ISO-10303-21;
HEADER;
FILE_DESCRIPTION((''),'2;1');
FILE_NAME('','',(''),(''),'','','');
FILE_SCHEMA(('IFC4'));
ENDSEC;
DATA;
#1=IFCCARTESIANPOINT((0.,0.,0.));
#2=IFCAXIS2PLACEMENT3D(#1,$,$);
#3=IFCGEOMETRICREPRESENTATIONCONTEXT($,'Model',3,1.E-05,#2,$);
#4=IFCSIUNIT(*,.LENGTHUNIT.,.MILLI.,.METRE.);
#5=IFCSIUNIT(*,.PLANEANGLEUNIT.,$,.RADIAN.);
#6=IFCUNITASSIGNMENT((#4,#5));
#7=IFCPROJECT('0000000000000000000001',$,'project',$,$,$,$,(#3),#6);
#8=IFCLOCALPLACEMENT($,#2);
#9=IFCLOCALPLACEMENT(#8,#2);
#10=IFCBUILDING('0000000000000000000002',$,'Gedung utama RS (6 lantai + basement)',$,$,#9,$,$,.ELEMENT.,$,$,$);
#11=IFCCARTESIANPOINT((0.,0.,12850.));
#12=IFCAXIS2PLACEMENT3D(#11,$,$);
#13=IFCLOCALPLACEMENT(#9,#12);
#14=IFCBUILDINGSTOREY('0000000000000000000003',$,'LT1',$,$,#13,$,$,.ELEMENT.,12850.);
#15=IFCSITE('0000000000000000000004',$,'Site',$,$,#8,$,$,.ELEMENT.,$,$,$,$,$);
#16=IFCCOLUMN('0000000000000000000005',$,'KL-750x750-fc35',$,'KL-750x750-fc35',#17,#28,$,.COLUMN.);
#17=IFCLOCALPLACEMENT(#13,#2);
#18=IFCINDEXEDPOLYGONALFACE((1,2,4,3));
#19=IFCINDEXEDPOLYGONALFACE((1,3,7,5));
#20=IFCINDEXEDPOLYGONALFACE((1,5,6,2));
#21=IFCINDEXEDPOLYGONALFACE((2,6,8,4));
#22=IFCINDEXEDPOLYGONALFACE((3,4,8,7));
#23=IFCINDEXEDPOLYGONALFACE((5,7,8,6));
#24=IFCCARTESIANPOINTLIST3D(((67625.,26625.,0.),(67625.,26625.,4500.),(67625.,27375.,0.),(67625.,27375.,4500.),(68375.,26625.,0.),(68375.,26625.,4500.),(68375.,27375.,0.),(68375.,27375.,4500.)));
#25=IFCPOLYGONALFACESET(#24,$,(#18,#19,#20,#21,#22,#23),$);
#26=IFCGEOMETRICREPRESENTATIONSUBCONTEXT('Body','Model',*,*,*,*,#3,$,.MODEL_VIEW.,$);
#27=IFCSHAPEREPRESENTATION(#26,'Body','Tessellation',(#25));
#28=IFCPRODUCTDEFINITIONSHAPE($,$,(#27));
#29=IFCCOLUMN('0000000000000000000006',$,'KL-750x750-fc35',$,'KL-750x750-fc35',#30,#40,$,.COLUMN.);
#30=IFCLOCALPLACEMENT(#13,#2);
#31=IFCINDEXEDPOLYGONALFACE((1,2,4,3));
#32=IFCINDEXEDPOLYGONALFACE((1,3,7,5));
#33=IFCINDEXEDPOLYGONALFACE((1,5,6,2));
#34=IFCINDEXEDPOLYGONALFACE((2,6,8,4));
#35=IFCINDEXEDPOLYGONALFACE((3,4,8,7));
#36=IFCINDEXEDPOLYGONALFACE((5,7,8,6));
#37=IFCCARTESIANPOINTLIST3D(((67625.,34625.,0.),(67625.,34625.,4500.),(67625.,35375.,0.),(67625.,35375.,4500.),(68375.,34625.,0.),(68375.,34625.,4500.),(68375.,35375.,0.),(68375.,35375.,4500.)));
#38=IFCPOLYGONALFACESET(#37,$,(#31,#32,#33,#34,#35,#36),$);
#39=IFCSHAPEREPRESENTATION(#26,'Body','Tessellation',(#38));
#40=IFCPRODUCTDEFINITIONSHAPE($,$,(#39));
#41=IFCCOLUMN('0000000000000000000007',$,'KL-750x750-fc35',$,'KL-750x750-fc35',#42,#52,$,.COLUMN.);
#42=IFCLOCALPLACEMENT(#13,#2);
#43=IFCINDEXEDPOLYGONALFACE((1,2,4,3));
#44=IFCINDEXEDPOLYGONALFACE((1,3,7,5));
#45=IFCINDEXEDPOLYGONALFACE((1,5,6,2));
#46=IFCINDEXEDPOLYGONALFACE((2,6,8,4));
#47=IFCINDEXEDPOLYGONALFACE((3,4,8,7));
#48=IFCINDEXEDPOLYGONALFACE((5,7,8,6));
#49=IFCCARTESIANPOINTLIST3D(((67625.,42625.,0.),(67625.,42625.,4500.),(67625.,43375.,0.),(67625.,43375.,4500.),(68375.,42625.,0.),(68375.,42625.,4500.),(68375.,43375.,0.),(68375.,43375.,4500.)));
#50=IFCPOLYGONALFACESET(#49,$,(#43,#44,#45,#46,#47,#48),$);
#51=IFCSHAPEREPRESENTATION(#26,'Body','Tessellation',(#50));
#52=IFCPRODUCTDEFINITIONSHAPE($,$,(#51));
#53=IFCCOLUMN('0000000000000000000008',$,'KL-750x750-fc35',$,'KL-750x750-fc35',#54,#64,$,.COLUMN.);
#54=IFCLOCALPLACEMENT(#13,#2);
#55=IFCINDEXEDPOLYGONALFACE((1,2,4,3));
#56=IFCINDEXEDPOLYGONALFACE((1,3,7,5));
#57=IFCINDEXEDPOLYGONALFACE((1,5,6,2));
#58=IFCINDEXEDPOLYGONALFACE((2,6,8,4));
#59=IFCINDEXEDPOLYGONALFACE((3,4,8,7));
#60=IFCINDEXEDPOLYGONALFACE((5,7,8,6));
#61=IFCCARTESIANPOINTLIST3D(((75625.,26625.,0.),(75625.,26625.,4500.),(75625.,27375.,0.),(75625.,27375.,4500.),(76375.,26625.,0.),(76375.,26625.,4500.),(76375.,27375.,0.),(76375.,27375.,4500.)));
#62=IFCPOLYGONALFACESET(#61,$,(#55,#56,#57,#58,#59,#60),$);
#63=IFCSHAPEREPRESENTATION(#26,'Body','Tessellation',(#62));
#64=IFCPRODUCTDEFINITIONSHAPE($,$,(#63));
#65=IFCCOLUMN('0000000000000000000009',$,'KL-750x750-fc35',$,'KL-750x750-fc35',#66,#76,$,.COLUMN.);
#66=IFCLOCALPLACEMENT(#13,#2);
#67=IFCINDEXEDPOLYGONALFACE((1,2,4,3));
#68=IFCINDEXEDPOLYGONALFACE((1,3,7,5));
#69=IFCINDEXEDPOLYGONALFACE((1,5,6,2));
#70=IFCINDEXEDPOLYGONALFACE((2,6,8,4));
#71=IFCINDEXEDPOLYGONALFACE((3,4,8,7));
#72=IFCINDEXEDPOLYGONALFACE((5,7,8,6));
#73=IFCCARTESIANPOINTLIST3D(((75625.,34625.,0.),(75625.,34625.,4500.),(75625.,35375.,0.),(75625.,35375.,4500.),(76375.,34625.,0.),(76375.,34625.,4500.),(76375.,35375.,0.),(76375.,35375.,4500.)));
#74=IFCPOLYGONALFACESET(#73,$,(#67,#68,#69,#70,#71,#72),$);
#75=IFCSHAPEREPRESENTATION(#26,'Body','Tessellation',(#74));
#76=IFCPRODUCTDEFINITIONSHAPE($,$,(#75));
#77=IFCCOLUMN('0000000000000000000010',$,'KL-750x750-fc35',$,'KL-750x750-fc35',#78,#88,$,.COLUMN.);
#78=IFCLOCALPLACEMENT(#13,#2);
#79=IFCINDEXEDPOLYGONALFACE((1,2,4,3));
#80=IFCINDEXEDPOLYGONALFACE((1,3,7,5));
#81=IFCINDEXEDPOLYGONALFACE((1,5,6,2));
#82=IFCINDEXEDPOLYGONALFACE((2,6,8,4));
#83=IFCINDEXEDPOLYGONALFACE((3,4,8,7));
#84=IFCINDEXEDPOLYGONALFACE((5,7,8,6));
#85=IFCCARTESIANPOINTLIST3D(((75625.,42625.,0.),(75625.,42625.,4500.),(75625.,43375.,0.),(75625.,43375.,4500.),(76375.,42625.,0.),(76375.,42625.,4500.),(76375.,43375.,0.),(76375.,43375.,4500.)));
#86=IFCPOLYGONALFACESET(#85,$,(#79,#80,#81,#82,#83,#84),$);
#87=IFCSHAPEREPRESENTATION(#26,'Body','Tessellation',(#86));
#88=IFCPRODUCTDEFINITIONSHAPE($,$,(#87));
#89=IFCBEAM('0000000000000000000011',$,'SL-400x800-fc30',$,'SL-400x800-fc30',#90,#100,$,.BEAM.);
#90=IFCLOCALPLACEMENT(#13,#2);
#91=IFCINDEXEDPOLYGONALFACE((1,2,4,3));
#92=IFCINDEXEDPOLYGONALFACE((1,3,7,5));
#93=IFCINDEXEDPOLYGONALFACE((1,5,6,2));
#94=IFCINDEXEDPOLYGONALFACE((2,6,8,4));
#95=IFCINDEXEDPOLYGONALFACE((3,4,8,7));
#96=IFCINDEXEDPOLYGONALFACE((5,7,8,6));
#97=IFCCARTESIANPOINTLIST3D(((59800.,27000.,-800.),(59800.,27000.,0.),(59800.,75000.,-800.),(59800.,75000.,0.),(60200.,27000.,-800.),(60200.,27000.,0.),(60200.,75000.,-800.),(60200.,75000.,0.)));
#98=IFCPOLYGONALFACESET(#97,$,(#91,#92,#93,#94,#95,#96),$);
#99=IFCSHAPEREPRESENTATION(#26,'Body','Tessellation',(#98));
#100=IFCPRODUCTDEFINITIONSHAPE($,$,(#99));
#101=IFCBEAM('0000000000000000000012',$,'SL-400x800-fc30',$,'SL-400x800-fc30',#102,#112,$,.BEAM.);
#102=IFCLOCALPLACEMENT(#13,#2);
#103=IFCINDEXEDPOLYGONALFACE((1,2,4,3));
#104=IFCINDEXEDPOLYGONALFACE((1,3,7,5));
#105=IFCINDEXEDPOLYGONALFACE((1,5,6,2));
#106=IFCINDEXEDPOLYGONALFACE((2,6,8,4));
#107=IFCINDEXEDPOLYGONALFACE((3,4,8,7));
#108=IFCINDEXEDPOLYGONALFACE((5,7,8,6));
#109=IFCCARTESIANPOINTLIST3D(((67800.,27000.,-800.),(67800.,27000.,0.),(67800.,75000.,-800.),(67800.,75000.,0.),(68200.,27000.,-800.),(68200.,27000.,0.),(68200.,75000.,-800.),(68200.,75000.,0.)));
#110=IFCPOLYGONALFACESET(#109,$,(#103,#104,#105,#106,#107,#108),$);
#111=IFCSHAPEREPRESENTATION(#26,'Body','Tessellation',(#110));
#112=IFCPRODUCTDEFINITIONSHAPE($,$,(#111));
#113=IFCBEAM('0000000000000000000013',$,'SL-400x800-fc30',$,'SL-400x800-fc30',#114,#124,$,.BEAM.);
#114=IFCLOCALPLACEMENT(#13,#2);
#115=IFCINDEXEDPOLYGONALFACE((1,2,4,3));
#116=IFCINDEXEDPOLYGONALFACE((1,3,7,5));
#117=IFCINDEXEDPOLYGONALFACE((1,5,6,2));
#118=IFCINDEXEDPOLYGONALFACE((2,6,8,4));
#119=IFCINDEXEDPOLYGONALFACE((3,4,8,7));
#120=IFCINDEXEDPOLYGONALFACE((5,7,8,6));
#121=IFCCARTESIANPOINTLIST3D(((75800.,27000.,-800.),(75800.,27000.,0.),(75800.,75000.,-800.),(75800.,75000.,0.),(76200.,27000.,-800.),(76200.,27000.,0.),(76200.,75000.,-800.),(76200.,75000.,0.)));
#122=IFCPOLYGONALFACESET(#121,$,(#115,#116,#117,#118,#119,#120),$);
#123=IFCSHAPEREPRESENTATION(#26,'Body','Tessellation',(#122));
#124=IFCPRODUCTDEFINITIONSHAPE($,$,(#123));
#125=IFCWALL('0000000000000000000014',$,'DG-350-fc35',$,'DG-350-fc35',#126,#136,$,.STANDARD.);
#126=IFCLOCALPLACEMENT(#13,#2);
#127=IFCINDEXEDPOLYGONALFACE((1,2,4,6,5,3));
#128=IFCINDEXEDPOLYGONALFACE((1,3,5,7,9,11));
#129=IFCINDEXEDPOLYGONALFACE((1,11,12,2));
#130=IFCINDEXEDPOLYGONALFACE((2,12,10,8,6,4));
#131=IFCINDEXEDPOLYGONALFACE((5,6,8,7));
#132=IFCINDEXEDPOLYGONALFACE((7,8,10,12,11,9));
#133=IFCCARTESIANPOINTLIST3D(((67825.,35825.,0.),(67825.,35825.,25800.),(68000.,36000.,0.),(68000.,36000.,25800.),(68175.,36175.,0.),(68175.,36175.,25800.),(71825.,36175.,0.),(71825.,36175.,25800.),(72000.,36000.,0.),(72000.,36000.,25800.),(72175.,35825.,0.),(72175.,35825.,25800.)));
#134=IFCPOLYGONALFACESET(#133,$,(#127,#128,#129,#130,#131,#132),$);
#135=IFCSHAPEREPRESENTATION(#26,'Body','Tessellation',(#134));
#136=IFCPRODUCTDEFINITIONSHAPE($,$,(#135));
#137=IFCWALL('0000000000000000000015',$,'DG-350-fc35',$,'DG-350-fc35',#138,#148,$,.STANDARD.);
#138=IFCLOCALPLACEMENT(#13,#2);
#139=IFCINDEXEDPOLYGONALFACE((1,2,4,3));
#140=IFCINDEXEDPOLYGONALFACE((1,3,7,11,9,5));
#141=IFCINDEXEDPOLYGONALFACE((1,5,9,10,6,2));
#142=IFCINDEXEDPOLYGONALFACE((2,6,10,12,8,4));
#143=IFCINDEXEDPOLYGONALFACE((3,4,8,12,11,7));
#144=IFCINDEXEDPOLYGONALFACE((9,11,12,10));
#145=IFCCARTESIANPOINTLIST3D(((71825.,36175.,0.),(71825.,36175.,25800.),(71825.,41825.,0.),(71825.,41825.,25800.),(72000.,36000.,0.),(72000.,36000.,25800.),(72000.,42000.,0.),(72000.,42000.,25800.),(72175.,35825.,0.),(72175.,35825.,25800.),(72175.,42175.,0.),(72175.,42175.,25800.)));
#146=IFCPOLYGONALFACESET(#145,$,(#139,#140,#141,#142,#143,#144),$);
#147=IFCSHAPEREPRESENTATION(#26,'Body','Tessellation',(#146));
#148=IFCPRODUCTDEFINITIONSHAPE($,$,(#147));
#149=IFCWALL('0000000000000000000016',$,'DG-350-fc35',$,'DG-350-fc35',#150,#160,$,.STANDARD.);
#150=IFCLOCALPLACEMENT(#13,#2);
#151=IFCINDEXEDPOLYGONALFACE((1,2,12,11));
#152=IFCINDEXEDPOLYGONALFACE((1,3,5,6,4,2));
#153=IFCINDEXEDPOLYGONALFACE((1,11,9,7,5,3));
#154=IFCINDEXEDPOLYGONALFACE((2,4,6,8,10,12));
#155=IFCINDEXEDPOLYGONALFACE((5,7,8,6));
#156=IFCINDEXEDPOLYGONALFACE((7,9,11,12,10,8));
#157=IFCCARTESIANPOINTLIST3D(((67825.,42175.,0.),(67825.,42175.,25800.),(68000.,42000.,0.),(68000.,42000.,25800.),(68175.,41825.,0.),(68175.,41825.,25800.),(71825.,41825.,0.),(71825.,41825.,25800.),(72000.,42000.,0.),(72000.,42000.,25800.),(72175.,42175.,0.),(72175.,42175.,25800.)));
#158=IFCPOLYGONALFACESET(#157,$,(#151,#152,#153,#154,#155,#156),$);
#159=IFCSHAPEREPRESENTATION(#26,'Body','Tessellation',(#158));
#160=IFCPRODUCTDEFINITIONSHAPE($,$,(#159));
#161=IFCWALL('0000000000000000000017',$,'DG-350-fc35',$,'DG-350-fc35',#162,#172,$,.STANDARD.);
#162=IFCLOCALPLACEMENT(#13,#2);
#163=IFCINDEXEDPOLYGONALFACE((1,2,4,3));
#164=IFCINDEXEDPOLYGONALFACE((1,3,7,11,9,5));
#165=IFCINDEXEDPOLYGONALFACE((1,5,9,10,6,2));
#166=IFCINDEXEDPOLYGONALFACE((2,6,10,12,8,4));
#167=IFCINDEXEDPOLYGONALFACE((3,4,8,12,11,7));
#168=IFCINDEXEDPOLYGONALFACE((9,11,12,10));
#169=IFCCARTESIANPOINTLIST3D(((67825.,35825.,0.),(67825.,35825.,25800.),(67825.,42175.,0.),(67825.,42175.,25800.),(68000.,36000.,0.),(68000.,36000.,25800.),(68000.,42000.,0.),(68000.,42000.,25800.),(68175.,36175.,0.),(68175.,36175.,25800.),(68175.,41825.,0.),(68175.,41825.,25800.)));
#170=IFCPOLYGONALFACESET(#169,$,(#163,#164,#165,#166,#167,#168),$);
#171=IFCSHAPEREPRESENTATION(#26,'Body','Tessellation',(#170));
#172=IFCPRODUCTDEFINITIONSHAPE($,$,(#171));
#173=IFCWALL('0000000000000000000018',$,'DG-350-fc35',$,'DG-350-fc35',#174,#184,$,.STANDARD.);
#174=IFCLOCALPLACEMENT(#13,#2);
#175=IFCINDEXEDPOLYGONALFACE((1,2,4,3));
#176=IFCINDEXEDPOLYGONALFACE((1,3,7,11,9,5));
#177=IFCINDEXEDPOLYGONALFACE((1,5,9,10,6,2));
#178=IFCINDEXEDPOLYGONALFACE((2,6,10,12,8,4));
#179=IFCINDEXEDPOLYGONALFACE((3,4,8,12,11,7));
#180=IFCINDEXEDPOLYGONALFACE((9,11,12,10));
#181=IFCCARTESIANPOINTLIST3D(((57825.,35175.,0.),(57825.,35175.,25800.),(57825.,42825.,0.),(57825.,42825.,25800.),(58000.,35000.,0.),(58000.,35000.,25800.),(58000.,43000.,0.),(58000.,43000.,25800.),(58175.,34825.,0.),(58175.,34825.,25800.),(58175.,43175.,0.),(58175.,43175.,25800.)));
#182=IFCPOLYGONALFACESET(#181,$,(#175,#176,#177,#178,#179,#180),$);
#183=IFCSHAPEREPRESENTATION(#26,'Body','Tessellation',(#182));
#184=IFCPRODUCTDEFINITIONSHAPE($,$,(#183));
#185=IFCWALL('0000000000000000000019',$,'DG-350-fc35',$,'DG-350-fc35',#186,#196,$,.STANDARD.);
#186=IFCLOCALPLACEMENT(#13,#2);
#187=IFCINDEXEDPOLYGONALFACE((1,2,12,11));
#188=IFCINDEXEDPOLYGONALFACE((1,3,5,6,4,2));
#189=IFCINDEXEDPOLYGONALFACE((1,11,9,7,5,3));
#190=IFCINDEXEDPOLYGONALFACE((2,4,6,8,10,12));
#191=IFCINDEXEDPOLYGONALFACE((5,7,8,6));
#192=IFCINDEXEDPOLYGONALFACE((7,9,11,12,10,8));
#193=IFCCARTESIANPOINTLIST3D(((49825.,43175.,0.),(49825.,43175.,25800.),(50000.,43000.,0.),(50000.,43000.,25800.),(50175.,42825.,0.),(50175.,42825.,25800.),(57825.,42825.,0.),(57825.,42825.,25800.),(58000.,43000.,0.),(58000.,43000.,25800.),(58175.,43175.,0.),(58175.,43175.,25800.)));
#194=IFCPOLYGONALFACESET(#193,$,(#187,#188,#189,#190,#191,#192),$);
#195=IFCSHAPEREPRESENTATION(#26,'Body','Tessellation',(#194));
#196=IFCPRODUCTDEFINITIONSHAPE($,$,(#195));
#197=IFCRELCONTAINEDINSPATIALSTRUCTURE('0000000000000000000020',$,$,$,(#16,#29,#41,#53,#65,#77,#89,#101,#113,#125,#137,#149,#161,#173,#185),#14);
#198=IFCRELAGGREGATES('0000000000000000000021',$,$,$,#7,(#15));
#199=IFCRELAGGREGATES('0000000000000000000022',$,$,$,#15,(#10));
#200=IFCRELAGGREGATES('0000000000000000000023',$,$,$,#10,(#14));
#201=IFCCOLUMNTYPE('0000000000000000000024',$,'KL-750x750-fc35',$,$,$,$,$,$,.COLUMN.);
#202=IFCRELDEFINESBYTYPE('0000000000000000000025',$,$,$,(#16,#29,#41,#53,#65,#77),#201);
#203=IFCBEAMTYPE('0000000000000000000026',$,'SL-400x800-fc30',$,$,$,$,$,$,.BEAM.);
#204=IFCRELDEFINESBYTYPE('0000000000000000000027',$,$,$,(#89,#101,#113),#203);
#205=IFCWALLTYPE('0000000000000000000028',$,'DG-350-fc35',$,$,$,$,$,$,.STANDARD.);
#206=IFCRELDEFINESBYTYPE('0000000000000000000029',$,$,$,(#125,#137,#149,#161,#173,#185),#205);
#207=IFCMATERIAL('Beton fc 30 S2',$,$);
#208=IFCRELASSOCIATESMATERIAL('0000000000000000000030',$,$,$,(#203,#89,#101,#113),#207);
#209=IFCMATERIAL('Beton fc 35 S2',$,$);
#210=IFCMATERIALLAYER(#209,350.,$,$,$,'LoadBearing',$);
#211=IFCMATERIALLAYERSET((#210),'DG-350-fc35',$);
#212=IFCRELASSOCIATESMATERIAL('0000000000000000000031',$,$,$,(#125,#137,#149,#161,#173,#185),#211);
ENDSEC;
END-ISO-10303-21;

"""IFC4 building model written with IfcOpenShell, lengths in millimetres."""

from ifc_helpers import new_model, si_unit, frame, origin, origin_2d, place, context, subcontext, project, spatial, polyline, rectangle, outline, extrude, material, layer, layer_set, layer_usage, material_profile, profile_set, profile_usage, type_object, element, save


model = new_model("IFC4")

# Units and contexts
model_context = context("Model", 3, precision=1e-05, world=origin())
body_context = subcontext(model_context, "Body", "Model", "MODEL_VIEW")
ifc_project = project(units=[si_unit("LENGTHUNIT", "METRE", prefix="MILLI"), si_unit("PLANEANGLEUNIT", "RADIAN")], contexts=[model_context])

# Site, building, storey
site_placement = place(None, origin())
site = spatial("IfcSite", under=ifc_project, at=site_placement, Name="Site", CompositionType="ELEMENT")
building_placement = place(site_placement, origin())
building = spatial("IfcBuilding", under=site, at=building_placement, Name="Gedung utama RS (6 lantai + basement)", CompositionType="ELEMENT")
storey_placement = place(building_placement, frame((0.0, 0.0, 12850.0)))
storey = spatial("IfcBuildingStorey", under=building, at=storey_placement, Name="LT1", CompositionType="ELEMENT", Elevation=12850.0)

# Columns
ifc_material_profile_1 = material_profile(None, rectangle(XDim=750.0, YDim=750.0, at=origin_2d()), Name="KL-750x750-fc35")
ifc_profile_set_1 = profile_set([ifc_material_profile_1], Name="KL-750x750-fc35")
ifc_profile_usage_1 = profile_usage(ifc_profile_set_1, cardinal=5)
column_type = type_object("IfcColumnType", Name="KL-750x750-fc35", PredefinedType="COLUMN", material=ifc_profile_set_1)
for number, where, z_axis, x_axis, name in (
    (1, (68000.0, 27000.0, 0.0), (0.0, 0.0, 1.0), (1.0, 0.0, 0.0), "KL-750x750-fc35"),
    (2, (68000.0, 35000.0, 0.0), (0.0, 0.0, 1.0), (1.0, 0.0, 0.0), "KL-750x750-fc35"),
    (3, (68000.0, 43000.0, 0.0), (0.0, 0.0, 1.0), (1.0, 0.0, 0.0), "KL-750x750-fc35"),
    (4, (76000.0, 27000.0, 0.0), (0.0, 0.0, 1.0), (1.0, 0.0, 0.0), "KL-750x750-fc35"),
    (5, (76000.0, 35000.0, 0.0), (0.0, 0.0, 1.0), (1.0, 0.0, 0.0), "KL-750x750-fc35"),
    (6, (76000.0, 43000.0, 0.0), (0.0, 0.0, 1.0), (1.0, 0.0, 0.0), "KL-750x750-fc35"),
):
    element("IfcColumn", number, at=place(storey_placement, frame(where, z_axis=z_axis, x_axis=x_axis)), inside=storey, type_object=column_type, material=ifc_profile_usage_1, Name=name, ObjectType="KL-750x750-fc35", PredefinedType="COLUMN", context=body_context, shape_type="SweptSolid", body=[
        extrude(rectangle(XDim=750.0, YDim=750.0, at=origin_2d()), origin(), (0.0, 0.0, 1.0), 4500.0),
    ])

# Beams
ifc_material_1 = material(Name="Beton fc 30 S2")
ifc_material_profile_2 = material_profile(ifc_material_1, rectangle(XDim=400.0, YDim=800.0, at=origin_2d()), Name="SL-400x800-fc30")
ifc_profile_set_2 = profile_set([ifc_material_profile_2], Name="SL-400x800-fc30")
ifc_profile_usage_2 = profile_usage(ifc_profile_set_2, cardinal=8)
beam_type = type_object("IfcBeamType", Name="SL-400x800-fc30", PredefinedType="BEAM", material=ifc_profile_set_2)
for number, where, name in (
    (7, (60000.0, 27000.0, -400.0), "SL-400x800-fc30"),
    (8, (68000.0, 27000.0, -400.0), "SL-400x800-fc30"),
    (9, (76000.0, 27000.0, -400.0), "SL-400x800-fc30"),
):
    element("IfcBeam", number, at=place(storey_placement, frame(where)), inside=storey, type_object=beam_type, material=ifc_profile_usage_2, Name=name, ObjectType="SL-400x800-fc30", PredefinedType="BEAM", context=body_context, shape_type="SweptSolid", body=[
        extrude(rectangle(XDim=400.0, YDim=800.0, at=origin_2d()), frame((0.0, 0.0, 0.0), z_axis=(0.0, 1.0, 0.0), x_axis=(-1.0, 0.0, 0.0)), (0.0, 0.0, 1.0), 48000.0),
    ])

# Walls
ifc_material_2 = material(Name="Beton fc 35 S2")
ifc_layer = layer(ifc_material_2, 350.0, Category="LoadBearing")
ifc_layer_set = layer_set([ifc_layer], Name="DG-350-fc35")
ifc_layer_usage = layer_usage(ifc_layer_set, "AXIS2", "NEGATIVE", 175.0)
wall_type = type_object("IfcWallType", Name="DG-350-fc35", PredefinedType="STANDARD")
wall_1_placement = place(storey_placement, frame((68000.0, 36000.0, 0.0), z_axis=(0.0, 0.0, 1.0), x_axis=(1.0, 0.0, 0.0)))
element("IfcWall", 10, at=wall_1_placement, inside=storey, type_object=wall_type, material=ifc_layer_usage, Name="DG-350-fc35", ObjectType="DG-350-fc35", PredefinedType="STANDARD", context=body_context, shape_type="SweptSolid", body=[
    extrude(outline(polyline([(-175.0, -175.0), (0.0, 0.0), (175.0, 175.0), (3825.0, 175.0), (4000.0, 0.0), (4175.0, -175.0), (-175.0, -175.0)])), origin(), (0.0, 0.0, 1.0), 25800.0),
])
wall_2_placement = place(storey_placement, frame((72000.0, 36000.0, 0.0), z_axis=(0.0, 0.0, 1.0), x_axis=(0.0, 1.0, 0.0)))
element("IfcWall", 11, at=wall_2_placement, inside=storey, type_object=wall_type, material=ifc_layer_usage, Name="DG-350-fc35", ObjectType="DG-350-fc35", PredefinedType="STANDARD", context=body_context, shape_type="SweptSolid", body=[
    extrude(outline(polyline([(-175.0, -175.0), (0.0, 0.0), (175.0, 175.0), (5825.0, 175.0), (6000.0, 0.0), (6175.0, -175.0), (-175.0, -175.0)])), origin(), (0.0, 0.0, 1.0), 25800.0),
])
wall_3_placement = place(storey_placement, frame((72000.0, 42000.0, 0.0), z_axis=(0.0, 0.0, 1.0), x_axis=(-1.0, 0.0, 0.0)))
element("IfcWall", 12, at=wall_3_placement, inside=storey, type_object=wall_type, material=ifc_layer_usage, Name="DG-350-fc35", ObjectType="DG-350-fc35", PredefinedType="STANDARD", context=body_context, shape_type="SweptSolid", body=[
    extrude(outline(polyline([(-175.0, -175.0), (0.0, 0.0), (175.0, 175.0), (3825.0, 175.0), (4000.0, 0.0), (4175.0, -175.0), (-175.0, -175.0)])), origin(), (0.0, 0.0, 1.0), 25800.0),
])
wall_4_placement = place(storey_placement, frame((68000.0, 42000.0, 0.0), z_axis=(0.0, 0.0, 1.0), x_axis=(0.0, -1.0, 0.0)))
element("IfcWall", 13, at=wall_4_placement, inside=storey, type_object=wall_type, material=ifc_layer_usage, Name="DG-350-fc35", ObjectType="DG-350-fc35", PredefinedType="STANDARD", context=body_context, shape_type="SweptSolid", body=[
    extrude(outline(polyline([(-175.0, -175.0), (0.0, 0.0), (175.0, 175.0), (5825.0, 175.0), (6000.0, 0.0), (6175.0, -175.0), (-175.0, -175.0)])), origin(), (0.0, 0.0, 1.0), 25800.0),
])
for number, where, z_axis, x_axis, name in (
    (14, (58000.0, 35000.0, 0.0), (0.0, 0.0, 1.0), (0.0, 1.0, 0.0), "DG-350-fc35"),
    (15, (58000.0, 43000.0, 0.0), (0.0, 0.0, 1.0), (-1.0, 0.0, 0.0), "DG-350-fc35"),
):
    element("IfcWall", number, at=place(storey_placement, frame(where, z_axis=z_axis, x_axis=x_axis)), inside=storey, type_object=wall_type, material=ifc_layer_usage, Name=name, ObjectType="DG-350-fc35", PredefinedType="STANDARD", context=body_context, shape_type="SweptSolid", body=[
        extrude(outline(polyline([(-175.0, -175.0), (0.0, 0.0), (175.0, 175.0), (7825.0, 175.0), (8000.0, 0.0), (8175.0, -175.0), (-175.0, -175.0)])), origin(), (0.0, 0.0, 1.0), 25800.0),
    ])

save(model, "model.ifc")
